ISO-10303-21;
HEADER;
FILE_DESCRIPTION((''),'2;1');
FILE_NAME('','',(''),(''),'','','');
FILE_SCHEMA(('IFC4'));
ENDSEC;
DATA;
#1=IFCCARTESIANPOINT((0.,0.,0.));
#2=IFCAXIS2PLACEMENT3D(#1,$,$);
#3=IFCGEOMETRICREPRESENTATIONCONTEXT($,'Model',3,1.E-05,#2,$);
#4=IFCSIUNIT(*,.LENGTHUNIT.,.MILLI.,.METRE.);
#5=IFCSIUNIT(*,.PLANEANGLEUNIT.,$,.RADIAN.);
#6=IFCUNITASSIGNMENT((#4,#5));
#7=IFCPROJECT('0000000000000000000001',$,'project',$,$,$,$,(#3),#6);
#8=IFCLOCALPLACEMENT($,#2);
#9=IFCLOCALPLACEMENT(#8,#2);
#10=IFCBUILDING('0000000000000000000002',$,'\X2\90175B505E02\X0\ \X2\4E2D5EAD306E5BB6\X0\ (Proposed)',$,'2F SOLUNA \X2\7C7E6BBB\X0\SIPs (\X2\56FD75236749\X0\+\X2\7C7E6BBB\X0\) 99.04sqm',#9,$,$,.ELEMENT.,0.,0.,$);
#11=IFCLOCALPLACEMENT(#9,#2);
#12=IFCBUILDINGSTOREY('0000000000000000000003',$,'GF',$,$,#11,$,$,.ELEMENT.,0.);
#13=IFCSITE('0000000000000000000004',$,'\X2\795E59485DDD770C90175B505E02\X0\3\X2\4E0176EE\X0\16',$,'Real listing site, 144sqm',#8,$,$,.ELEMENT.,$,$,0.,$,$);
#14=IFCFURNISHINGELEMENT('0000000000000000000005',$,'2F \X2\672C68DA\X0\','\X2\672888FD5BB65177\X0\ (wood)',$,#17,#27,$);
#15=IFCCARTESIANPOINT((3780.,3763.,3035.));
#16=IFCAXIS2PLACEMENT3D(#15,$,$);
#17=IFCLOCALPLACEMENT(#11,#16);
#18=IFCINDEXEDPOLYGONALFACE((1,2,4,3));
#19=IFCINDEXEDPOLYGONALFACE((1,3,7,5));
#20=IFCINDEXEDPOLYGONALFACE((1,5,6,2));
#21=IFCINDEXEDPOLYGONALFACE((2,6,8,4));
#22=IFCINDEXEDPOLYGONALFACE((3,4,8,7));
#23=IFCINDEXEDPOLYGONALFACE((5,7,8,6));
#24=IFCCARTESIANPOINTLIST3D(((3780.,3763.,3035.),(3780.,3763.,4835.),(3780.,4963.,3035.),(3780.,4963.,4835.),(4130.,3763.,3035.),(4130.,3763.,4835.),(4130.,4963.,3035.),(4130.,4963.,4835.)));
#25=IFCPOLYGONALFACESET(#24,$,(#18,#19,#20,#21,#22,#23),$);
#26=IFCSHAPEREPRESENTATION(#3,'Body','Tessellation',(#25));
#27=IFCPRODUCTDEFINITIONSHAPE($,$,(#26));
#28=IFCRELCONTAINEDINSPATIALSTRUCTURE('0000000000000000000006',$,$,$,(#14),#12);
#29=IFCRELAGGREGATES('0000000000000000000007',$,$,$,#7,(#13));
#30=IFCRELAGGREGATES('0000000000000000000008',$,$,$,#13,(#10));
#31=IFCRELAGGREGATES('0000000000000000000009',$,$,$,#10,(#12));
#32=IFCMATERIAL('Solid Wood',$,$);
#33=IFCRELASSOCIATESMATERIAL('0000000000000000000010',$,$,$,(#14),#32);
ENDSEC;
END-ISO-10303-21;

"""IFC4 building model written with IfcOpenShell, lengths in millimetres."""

from ifc_helpers import new_model, si_unit, frame, frame_2d, origin, place, context, project, spatial, rectangle, extrude, material, element, save


model = new_model("IFC4")

# Units and contexts
model_context = context("Model", 3, precision=1e-05, world=origin())
ifc_project = project(units=[si_unit("LENGTHUNIT", "METRE", prefix="MILLI"), si_unit("PLANEANGLEUNIT", "RADIAN")], contexts=[model_context])

# Site, building, storey
site_placement = place(None, origin())
site = spatial("IfcSite", under=ifc_project, at=site_placement, Name="神奈川県逗子市3丁目16", ObjectType="Real listing site, 144sqm", CompositionType="ELEMENT", RefElevation=0.0)
building_placement = place(site_placement, origin())
building = spatial("IfcBuilding", under=site, at=building_placement, Name="逗子市 中庭の家 (Proposed)", ObjectType="2F SOLUNA 籾殻SIPs (国産杉+籾殻) 99.04sqm", CompositionType="ELEMENT", ElevationOfRefHeight=0.0, ElevationOfTerrain=0.0)
storey_placement = place(building_placement, origin())
storey = spatial("IfcBuildingStorey", under=building, at=storey_placement, Name="GF", CompositionType="ELEMENT", Elevation=0.0)

# Shared definitions
ifc_material_1 = material(Name="Solid Wood")

# Furnishing element
furnishing_placement = place(storey_placement, frame((3780.0, 3763.0, 3035.0)))
element("IfcFurnishingElement", 1, at=furnishing_placement, inside=storey, material=ifc_material_1, Name="2F 本棚", Description="木製家具 (wood)", context=model_context, shape_type="SweptSolid", body=[
    extrude(rectangle(XDim=350.0, YDim=1200.0, at=frame_2d((175.0, 600.0))), frame((3780.0, 3763.0, 3035.0)), (0.0, 0.0, 1.0), 1800.0),
])

save(model, "model.ifc")
